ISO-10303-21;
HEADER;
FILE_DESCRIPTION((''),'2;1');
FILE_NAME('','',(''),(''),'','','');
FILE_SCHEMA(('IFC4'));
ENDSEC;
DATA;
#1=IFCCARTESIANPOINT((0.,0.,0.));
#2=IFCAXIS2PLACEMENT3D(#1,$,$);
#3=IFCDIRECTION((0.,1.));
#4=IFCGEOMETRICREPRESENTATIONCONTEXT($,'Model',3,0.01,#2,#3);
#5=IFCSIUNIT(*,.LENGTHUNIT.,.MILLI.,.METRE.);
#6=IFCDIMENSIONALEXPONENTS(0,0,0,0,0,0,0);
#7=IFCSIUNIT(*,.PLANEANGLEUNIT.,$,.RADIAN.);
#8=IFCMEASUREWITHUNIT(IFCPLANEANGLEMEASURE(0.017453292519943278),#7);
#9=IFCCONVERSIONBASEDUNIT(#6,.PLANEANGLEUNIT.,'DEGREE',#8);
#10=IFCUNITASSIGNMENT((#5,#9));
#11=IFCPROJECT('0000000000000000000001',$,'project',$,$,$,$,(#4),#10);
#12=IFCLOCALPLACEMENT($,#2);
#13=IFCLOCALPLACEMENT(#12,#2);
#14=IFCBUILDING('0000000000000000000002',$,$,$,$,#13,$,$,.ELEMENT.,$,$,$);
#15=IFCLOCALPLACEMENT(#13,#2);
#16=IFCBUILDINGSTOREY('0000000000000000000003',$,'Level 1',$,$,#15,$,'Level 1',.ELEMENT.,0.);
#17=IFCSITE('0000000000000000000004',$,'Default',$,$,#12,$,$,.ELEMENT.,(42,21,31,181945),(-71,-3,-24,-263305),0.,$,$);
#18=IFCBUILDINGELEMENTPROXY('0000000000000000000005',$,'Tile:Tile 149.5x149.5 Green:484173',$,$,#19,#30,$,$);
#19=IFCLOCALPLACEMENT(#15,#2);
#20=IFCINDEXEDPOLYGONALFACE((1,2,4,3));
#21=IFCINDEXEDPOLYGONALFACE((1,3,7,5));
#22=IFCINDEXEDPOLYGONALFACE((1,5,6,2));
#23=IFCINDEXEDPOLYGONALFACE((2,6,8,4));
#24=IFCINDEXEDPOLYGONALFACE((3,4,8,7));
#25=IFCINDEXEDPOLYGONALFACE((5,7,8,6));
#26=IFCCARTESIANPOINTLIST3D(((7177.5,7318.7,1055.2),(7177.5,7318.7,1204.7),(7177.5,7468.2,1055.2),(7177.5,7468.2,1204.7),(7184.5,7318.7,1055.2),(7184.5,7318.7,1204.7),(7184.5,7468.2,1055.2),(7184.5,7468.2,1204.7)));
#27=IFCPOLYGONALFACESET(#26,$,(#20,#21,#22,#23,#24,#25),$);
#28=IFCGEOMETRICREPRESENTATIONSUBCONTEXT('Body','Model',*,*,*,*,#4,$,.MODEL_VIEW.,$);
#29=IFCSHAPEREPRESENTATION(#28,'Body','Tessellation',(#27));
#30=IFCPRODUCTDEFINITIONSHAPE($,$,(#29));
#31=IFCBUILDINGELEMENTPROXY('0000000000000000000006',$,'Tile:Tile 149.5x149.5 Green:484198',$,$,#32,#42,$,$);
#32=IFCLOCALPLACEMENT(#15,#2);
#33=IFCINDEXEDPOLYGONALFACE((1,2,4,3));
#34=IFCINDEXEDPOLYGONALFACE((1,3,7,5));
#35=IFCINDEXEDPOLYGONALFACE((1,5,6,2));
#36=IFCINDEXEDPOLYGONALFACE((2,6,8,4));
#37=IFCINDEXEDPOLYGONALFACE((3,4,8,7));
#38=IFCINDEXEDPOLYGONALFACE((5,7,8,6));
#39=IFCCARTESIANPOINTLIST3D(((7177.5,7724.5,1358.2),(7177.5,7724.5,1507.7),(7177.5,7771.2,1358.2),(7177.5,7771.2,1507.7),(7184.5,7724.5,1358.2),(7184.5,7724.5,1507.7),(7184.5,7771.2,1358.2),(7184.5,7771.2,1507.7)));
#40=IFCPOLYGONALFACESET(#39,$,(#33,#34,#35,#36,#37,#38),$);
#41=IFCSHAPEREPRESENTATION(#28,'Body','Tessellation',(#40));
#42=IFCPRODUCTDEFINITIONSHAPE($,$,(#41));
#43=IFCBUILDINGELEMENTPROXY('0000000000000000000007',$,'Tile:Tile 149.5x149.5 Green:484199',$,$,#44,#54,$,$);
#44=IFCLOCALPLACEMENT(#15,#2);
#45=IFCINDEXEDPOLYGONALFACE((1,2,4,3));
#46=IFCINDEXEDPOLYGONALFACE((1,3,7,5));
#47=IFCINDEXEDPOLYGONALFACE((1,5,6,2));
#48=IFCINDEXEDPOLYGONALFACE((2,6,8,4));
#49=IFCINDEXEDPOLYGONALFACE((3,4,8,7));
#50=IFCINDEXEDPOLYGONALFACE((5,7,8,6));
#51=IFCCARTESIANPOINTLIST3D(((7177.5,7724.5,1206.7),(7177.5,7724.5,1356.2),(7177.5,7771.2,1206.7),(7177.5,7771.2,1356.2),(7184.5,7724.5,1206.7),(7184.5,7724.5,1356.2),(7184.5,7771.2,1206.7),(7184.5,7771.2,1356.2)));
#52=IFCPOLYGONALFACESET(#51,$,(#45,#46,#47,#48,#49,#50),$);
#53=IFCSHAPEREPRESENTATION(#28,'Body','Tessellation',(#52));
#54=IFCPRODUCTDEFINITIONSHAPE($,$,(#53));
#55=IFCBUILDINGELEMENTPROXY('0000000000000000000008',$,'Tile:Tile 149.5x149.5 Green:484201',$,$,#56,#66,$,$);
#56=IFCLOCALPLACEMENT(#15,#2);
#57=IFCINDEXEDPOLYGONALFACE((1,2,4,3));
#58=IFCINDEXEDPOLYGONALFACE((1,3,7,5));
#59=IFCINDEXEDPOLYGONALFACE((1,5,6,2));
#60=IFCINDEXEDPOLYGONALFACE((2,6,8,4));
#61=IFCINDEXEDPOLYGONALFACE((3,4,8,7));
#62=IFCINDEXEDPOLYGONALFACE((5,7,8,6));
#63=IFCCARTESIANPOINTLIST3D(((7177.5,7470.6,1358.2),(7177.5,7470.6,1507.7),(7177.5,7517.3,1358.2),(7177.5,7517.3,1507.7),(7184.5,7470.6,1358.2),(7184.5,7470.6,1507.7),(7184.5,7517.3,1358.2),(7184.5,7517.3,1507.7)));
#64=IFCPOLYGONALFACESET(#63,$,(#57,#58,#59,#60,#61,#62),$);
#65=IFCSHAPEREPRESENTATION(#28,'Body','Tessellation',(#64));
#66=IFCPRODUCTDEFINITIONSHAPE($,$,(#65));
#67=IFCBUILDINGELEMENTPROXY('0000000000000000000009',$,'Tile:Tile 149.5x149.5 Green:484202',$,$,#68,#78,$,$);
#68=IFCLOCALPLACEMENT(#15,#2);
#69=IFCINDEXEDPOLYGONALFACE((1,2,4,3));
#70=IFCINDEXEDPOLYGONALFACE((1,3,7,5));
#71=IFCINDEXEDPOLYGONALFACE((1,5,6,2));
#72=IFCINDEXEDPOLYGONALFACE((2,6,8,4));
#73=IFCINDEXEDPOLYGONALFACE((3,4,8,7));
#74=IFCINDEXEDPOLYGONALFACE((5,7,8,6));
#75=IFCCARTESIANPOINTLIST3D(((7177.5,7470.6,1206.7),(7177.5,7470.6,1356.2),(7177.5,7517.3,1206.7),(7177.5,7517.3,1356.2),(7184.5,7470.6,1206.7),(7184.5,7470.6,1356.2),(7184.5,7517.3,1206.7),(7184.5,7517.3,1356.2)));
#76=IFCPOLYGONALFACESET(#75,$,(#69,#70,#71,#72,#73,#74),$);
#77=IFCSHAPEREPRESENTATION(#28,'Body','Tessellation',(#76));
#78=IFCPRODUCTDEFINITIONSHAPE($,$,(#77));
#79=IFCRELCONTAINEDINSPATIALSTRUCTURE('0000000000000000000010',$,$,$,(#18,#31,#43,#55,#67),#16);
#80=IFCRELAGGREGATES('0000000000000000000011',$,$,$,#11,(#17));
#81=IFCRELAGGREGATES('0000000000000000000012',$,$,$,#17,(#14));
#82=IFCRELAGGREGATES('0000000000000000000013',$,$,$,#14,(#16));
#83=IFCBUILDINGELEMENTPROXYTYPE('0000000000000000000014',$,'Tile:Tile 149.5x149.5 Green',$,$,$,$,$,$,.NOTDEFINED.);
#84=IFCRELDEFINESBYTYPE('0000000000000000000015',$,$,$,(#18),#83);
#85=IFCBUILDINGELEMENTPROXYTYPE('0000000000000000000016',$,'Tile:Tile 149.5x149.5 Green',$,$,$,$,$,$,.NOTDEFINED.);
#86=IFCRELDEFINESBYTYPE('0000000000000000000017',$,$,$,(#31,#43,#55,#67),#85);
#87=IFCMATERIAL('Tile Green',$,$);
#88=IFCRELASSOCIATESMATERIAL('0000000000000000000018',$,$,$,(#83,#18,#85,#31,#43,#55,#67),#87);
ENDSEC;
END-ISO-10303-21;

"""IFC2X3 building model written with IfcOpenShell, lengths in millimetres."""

from ifc_helpers import new_model, entity, si_unit, converted_unit, direction, frame, origin, origin_2d_with_axis, place, context, subcontext, project, spatial, rectangle, extrude, source, transform, mapped, material, type_object, type_shapes, element, save


model = new_model("IFC2X3")

# Units and contexts
model_context = context("Model", 3, precision=0.01, world=origin(), true_north=direction((0.0, 1.0)))
body_context = subcontext(model_context, "Body", "Model", "MODEL_VIEW")
ifc_project = project(units=[si_unit("LENGTHUNIT", "METRE", prefix="MILLI"), converted_unit("PLANEANGLEUNIT", "DEGREE", entity("IfcPlaneAngleMeasure", 0.017453292519943278), si_unit("PLANEANGLEUNIT", "RADIAN"), dimensions=[0, 0, 0, 0, 0, 0, 0])], contexts=[model_context])

# Site, building, storey
site_placement = place(None, origin())
site = spatial("IfcSite", under=ifc_project, at=site_placement, Name="Default", CompositionType="ELEMENT", RefLatitude=(42, 21, 31, 181945), RefLongitude=(-71, -3, -24, -263305), RefElevation=0.0)
building_placement = place(site_placement, origin())
building = spatial("IfcBuilding", under=site, at=building_placement, CompositionType="ELEMENT")
storey_placement = place(building_placement, origin())
storey = spatial("IfcBuildingStorey", under=building, at=storey_placement, Name="Level 1", LongName="Level 1", CompositionType="ELEMENT", Elevation=0.0)

# Building element proxies
ifc_material_1 = material(Name="Tile Green")
building_element_proxy_type_1 = type_object("IfcBuildingElementProxyType", Name="Tile:Tile 149.5x149.5 Green", PredefinedType="NOTDEFINED", material=ifc_material_1)
shared_shape_1 = source(origin(), body_context, "Body", "SweptSolid", [
    extrude(rectangle(XDim=149.5, YDim=149.5, at=origin_2d_with_axis()), frame((-74.7, -74.8, 0.0), z_axis=(0.0, 0.0, 1.0), x_axis=(0.0, -1.0, 0.0)), (0.0, 0.0, 1.0), 7.0),
])
type_shapes(building_element_proxy_type_1, [shared_shape_1])
for number, where, z_axis, x_axis, name in (
    (1, (7184.5, 7468.2, 1204.7), (-1.0, 0.0, 0.0), (0.0, 0.0, 1.0), "Tile:Tile 149.5x149.5 Green:484173"),
):
    element("IfcBuildingElementProxy", number, at=place(storey_placement, frame(where, z_axis=z_axis, x_axis=x_axis)), inside=storey, type_object=building_element_proxy_type_1, material=ifc_material_1, Name=name, context=body_context, shape_type="MappedRepresentation", body=[
        mapped(shared_shape_1, transform((0.0, 0.0, 0.0), scale=1.0)),
    ])
building_element_proxy_type_2 = type_object("IfcBuildingElementProxyType", Name="Tile:Tile 149.5x149.5 Green", PredefinedType="NOTDEFINED", material=ifc_material_1)
shared_shape_2 = source(origin(), body_context, "Body", "SweptSolid", [
    extrude(rectangle(XDim=46.7, YDim=149.5, at=origin_2d_with_axis()), frame((-23.3, -74.8, 0.0), z_axis=(0.0, 0.0, 1.0), x_axis=(-1.0, 0.0, 0.0)), (0.0, 0.0, 1.0), 7.0),
])
type_shapes(building_element_proxy_type_2, [shared_shape_2])
for number, where, z_axis, x_axis, name in (
    (2, (7184.5, 7771.2, 1358.2), (-1.0, 0.0, 0.0), (0.0, 1.0, 0.0), "Tile:Tile 149.5x149.5 Green:484198"),
    (3, (7184.5, 7771.2, 1206.7), (-1.0, 0.0, 0.0), (0.0, 1.0, 0.0), "Tile:Tile 149.5x149.5 Green:484199"),
    (4, (7184.5, 7517.3, 1358.2), (-1.0, 0.0, 0.0), (0.0, 1.0, 0.0), "Tile:Tile 149.5x149.5 Green:484201"),
    (5, (7184.5, 7517.3, 1206.7), (-1.0, 0.0, 0.0), (0.0, 1.0, 0.0), "Tile:Tile 149.5x149.5 Green:484202"),
):
    element("IfcBuildingElementProxy", number, at=place(storey_placement, frame(where, z_axis=z_axis, x_axis=x_axis)), inside=storey, type_object=building_element_proxy_type_2, material=ifc_material_1, Name=name, context=body_context, shape_type="MappedRepresentation", body=[
        mapped(shared_shape_2, transform((0.0, 0.0, 0.0), scale=1.0)),
    ])

save(model, "model.ifc")
